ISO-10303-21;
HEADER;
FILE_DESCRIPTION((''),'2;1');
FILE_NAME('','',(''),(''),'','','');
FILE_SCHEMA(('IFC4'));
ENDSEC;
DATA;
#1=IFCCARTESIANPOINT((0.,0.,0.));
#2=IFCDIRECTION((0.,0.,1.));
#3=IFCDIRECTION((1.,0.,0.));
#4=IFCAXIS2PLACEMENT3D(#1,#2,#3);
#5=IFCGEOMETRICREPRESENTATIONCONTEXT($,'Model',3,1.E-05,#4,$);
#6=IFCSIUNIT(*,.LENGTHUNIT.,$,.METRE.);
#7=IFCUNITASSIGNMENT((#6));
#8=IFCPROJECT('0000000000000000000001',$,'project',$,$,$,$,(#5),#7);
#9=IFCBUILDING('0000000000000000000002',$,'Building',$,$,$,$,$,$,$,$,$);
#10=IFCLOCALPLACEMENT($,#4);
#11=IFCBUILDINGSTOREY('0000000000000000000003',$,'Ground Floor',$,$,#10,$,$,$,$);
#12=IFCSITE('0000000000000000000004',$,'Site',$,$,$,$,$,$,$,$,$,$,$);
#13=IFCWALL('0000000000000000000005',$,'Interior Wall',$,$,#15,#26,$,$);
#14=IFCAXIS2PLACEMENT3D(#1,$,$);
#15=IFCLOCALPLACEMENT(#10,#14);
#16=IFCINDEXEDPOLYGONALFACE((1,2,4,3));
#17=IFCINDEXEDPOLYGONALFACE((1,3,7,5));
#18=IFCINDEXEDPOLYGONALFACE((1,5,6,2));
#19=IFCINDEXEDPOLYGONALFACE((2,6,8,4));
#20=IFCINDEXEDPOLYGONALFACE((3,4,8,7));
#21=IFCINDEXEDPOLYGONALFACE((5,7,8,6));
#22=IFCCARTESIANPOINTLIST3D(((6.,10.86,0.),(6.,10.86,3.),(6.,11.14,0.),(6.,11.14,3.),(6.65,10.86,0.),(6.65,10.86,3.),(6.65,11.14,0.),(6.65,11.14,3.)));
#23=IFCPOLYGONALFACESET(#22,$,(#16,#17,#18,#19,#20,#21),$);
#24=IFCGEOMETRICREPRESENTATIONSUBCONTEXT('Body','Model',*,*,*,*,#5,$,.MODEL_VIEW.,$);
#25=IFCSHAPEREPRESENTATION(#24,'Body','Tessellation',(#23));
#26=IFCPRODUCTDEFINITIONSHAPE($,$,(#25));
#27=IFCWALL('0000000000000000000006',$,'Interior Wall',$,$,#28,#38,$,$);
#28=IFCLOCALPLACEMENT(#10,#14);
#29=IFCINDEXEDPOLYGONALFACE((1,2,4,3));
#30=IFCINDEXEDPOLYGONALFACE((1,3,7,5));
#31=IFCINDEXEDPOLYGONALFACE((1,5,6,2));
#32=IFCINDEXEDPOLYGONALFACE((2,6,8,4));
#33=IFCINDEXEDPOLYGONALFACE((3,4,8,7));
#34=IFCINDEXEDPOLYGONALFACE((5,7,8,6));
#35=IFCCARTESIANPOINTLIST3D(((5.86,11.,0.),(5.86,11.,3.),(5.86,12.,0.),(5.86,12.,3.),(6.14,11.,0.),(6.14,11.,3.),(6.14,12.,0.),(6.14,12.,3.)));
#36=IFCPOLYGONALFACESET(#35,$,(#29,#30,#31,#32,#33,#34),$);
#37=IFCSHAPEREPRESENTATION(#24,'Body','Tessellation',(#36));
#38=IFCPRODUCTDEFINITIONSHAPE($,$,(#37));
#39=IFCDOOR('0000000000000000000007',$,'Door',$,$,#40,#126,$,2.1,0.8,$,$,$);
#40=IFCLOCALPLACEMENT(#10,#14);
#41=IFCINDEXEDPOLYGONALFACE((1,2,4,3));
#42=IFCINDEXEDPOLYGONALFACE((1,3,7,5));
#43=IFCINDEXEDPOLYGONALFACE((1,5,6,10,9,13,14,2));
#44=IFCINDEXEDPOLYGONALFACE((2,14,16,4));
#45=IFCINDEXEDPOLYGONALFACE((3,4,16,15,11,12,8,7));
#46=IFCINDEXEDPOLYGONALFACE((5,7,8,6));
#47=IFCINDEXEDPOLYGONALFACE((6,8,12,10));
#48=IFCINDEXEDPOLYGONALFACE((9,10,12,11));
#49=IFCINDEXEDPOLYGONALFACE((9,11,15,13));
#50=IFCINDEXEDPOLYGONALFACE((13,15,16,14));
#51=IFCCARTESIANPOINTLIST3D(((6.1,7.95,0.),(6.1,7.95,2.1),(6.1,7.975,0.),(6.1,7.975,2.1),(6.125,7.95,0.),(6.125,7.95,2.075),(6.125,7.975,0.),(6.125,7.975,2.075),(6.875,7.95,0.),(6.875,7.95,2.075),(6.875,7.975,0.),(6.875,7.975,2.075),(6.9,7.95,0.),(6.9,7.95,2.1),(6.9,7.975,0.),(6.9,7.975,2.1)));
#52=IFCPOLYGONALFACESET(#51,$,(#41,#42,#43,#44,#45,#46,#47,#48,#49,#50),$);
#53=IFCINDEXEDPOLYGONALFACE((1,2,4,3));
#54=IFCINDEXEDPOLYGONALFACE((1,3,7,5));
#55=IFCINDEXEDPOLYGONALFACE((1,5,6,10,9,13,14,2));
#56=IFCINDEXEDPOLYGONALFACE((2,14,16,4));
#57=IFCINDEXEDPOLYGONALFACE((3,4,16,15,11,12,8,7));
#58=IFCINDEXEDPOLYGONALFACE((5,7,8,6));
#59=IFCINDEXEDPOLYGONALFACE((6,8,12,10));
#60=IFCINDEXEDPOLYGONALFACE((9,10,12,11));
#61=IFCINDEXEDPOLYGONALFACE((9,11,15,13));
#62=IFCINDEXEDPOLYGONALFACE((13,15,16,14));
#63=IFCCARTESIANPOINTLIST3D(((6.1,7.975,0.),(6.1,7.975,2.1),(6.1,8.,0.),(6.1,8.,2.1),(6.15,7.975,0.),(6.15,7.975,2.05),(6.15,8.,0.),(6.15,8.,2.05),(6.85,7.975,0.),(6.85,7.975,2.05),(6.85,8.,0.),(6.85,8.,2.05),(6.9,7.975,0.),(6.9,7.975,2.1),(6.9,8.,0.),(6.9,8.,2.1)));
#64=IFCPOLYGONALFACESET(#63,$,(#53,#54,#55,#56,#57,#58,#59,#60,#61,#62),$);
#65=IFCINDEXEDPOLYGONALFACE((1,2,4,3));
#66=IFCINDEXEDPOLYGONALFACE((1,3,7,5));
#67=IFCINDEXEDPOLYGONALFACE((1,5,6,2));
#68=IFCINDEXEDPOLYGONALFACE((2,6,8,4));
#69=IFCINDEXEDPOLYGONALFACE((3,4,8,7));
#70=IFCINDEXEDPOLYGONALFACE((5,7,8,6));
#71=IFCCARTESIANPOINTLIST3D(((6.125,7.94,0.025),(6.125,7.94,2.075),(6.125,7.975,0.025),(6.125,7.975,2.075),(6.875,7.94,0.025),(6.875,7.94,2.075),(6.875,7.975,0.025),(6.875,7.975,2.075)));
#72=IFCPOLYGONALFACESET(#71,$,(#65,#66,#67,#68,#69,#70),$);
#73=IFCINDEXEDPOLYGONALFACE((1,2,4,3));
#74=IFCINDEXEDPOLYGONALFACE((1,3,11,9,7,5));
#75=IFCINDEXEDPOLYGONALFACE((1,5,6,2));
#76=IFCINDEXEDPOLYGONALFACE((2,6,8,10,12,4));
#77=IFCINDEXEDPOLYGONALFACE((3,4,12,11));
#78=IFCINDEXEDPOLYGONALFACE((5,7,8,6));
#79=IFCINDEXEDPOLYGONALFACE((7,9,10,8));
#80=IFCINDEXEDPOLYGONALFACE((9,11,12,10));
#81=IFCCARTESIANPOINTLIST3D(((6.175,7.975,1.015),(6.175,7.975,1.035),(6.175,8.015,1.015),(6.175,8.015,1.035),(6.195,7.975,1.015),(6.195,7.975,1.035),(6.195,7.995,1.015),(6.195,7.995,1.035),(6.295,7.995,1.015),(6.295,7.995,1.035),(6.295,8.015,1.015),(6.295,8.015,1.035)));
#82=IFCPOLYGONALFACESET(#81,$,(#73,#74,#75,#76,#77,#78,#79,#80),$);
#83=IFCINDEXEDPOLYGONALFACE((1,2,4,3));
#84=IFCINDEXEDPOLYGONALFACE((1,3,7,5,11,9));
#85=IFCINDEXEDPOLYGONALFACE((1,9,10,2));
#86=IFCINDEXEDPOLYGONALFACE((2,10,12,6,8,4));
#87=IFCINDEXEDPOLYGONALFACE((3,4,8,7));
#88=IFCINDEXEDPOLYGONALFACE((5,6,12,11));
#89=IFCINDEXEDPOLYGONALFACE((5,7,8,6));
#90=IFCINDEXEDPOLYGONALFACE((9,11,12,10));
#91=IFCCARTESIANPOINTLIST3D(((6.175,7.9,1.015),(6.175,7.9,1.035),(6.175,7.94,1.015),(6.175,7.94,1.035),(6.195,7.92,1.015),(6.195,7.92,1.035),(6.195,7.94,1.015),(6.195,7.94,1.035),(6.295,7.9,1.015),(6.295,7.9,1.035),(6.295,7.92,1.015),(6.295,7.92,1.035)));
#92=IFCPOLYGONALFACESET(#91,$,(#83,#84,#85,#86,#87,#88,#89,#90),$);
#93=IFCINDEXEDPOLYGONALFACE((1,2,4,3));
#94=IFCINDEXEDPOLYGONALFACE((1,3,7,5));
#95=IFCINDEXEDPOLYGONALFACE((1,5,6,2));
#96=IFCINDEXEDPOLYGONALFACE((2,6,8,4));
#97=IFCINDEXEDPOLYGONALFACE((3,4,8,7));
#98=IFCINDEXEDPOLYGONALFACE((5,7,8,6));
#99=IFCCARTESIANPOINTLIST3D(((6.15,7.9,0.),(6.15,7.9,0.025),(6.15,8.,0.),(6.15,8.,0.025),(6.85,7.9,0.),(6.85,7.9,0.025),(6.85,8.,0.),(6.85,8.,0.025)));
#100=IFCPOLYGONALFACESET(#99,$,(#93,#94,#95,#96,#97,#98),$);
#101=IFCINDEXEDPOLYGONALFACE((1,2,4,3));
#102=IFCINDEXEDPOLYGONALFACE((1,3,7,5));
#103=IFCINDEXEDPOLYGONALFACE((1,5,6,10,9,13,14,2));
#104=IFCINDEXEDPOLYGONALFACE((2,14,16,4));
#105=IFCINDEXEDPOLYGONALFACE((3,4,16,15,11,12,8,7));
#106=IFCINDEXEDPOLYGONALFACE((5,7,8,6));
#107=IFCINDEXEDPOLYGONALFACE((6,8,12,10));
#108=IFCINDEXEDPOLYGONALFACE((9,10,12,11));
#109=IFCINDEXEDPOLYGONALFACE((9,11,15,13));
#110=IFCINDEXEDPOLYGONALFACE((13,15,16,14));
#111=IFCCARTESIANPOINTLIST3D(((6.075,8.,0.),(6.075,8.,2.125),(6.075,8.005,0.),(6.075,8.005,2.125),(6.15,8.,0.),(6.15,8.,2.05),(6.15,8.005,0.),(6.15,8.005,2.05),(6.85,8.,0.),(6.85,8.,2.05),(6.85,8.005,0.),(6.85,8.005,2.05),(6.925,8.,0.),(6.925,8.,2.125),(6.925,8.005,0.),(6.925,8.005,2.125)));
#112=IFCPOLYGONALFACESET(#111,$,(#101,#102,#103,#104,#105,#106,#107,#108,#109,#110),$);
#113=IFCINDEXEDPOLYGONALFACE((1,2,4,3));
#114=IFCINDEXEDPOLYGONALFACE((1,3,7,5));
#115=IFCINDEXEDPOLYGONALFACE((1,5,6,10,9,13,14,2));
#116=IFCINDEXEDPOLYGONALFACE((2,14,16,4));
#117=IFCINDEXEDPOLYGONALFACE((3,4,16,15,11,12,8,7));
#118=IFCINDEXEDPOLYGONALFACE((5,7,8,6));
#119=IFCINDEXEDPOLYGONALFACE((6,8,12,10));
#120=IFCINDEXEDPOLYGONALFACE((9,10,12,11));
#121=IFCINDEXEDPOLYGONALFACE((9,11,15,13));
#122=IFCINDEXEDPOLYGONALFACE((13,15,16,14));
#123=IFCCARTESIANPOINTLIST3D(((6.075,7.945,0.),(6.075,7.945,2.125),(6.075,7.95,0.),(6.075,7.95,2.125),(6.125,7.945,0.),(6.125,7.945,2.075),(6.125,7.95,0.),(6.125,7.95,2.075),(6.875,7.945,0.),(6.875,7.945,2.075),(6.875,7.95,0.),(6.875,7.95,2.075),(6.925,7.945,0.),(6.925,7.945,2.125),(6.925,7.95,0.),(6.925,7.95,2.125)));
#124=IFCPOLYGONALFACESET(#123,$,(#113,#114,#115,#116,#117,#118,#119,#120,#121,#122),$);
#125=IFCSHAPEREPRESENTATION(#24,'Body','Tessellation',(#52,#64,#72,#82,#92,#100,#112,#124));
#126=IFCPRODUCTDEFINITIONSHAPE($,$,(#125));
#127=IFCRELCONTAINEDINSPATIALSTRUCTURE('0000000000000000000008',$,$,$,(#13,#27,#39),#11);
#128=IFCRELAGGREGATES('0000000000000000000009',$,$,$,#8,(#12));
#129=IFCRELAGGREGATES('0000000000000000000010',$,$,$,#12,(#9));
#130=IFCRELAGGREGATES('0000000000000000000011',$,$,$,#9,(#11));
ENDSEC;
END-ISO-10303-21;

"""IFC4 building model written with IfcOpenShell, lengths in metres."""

from ifc_helpers import new_model, si_unit, frame, origin_with_axes, place, context, subcontext, project, spatial, line, indexed_curve, outline, extrude, element, save


model = new_model("IFC4")

# Units and contexts
model_context = context("Model", 3, precision=1e-05, world=origin_with_axes())
body_context = subcontext(model_context, "Body", "Model", "MODEL_VIEW")
ifc_project = project(units=[si_unit("LENGTHUNIT", "METRE")], contexts=[model_context])

# Site, building, storey
site = spatial("IfcSite", under=ifc_project, Name="Site")
building = spatial("IfcBuilding", under=site, Name="Building")
storey_placement = place(None, origin_with_axes())
storey = spatial("IfcBuildingStorey", under=building, at=storey_placement, Name="Ground Floor")

# Walls
for number, where, z_axis, x_axis, name in (
    (1, (6.65, 11.0, 0.0), (0.0, 0.0, 1.0), (-1.0, 0.0, 0.0), "Interior Wall"),
):
    element("IfcWall", number, at=place(storey_placement, frame(where, z_axis=z_axis, x_axis=x_axis)), inside=storey, Name=name, context=body_context, shape_type="SweptSolid", body=[
        extrude(outline(indexed_curve([(0.0, 0.0), (0.0, 0.28), (0.65, 0.28), (0.65, 0.0), (0.0, 0.0)], self_intersect=False)), frame((0.0, -0.14, 0.0), z_axis=(0.0, 0.0, 1.0), x_axis=(1.0, 0.0, 0.0)), (0.0, 0.0, 1.0), 3.0),
    ])
wall_1_placement = place(storey_placement, frame((6.0, 12.0, 0.0), z_axis=(0.0, 0.0, 1.0), x_axis=(0.0, -1.0, 0.0)))
element("IfcWall", 2, at=wall_1_placement, inside=storey, Name="Interior Wall", context=body_context, shape_type="SweptSolid", body=[
    extrude(outline(indexed_curve([(0.0, 0.0), (0.0, 0.28), (1.0, 0.28), (1.0, 0.0), (0.0, 0.0)], self_intersect=False)), frame((0.0, -0.14, 0.0), z_axis=(0.0, 0.0, 1.0), x_axis=(1.0, 0.0, 0.0)), (0.0, 0.0, 1.0), 3.0),
])

# Door
door_1_placement = place(storey_placement, frame((6.9, 8.0, 0.0), z_axis=(0.0, 0.0, 1.0), x_axis=(-1.0, 0.0, 0.0)))
element("IfcDoor", 3, at=door_1_placement, inside=storey, Name="Door", OverallHeight=2.1, OverallWidth=0.8, context=body_context, shape_type="SweptSolid", body=[
    extrude(outline(indexed_curve([(0.0, 0.0), (0.0, 2.1), (0.8, 2.1), (0.8, 0.0), (0.775, 0.0), (0.775, 2.075), (0.025, 2.075), (0.025, 0.0)], segments=[line(1, 2, 3, 4, 5, 6, 7, 8, 1)])), frame((0.0, 0.025, 0.0), z_axis=(0.0, -1.0, 0.0), x_axis=(1.0, 0.0, 0.0)), (0.0, 0.0, -1.0), 0.025),
    extrude(outline(indexed_curve([(0.0, 0.0), (0.0, 2.1), (0.8, 2.1), (0.8, 0.0), (0.75, 0.0), (0.75, 2.05), (0.05, 2.05), (0.05, 0.0)], segments=[line(1, 2, 3, 4, 5, 6, 7, 8, 1)])), frame((0.0, 0.0, 0.0), z_axis=(0.0, -1.0, 0.0), x_axis=(1.0, 0.0, 0.0)), (0.0, 0.0, -1.0), 0.025),
    extrude(outline(indexed_curve([(0.0, 0.0), (0.75, 0.0), (0.75, 0.035), (0.0, 0.035)], segments=[line(1, 2, 3, 4, 1)])), frame((0.025, 0.025, 0.025), z_axis=(0.0, 0.0, 1.0), x_axis=(1.0, 0.0, 0.0)), (0.0, 0.0, 1.0), 2.05),
    extrude(outline(indexed_curve([(0.0, 0.0), (0.0, -0.04), (-0.12, -0.04), (-0.12, -0.02), (-0.02, -0.02), (-0.02, 0.0)], segments=[line(1, 2, 3, 4, 5, 6, 1)])), frame((0.725, 0.025, 1.015), z_axis=(0.0, 0.0, 1.0), x_axis=(1.0, 0.0, 0.0)), (0.0, 0.0, 1.0), 0.02),
    extrude(outline(indexed_curve([(0.0, 0.0), (0.0, 0.04), (-0.12, 0.04), (-0.12, 0.02), (-0.02, 0.02), (-0.02, 0.0)], segments=[line(1, 2, 3, 4, 5, 6, 1)])), frame((0.725, 0.06, 1.015), z_axis=(0.0, 0.0, 1.0), x_axis=(1.0, 0.0, 0.0)), (0.0, 0.0, 1.0), 0.02),
    extrude(outline(indexed_curve([(0.0, 0.0), (0.7, 0.0), (0.7, 0.1), (0.0, 0.1)], segments=[line(1, 2, 3, 4, 1)])), frame((0.05, 0.0, 0.0), z_axis=(0.0, 0.0, 1.0), x_axis=(1.0, 0.0, 0.0)), (0.0, 0.0, 1.0), 0.025),
    extrude(outline(indexed_curve([(0.0, 0.0), (0.0, 2.125), (0.85, 2.125), (0.85, 0.0), (0.775, 0.0), (0.775, 2.05), (0.075, 2.05), (0.075, 0.0)], segments=[line(1, 2, 3, 4, 5, 6, 7, 8, 1)])), frame((-0.025, -0.005, 0.0), z_axis=(0.0, -1.0, 0.0), x_axis=(1.0, 0.0, 0.0)), (0.0, 0.0, -1.0), 0.005),
    extrude(outline(indexed_curve([(0.0, 0.0), (0.0, 2.125), (0.85, 2.125), (0.85, 0.0), (0.8, 0.0), (0.8, 2.075), (0.05, 2.075), (0.05, 0.0)], segments=[line(1, 2, 3, 4, 5, 6, 7, 8, 1)])), frame((-0.025, 0.05, 0.0), z_axis=(0.0, -1.0, 0.0), x_axis=(1.0, 0.0, 0.0)), (0.0, 0.0, -1.0), 0.005),
])

save(model, "model.ifc")
